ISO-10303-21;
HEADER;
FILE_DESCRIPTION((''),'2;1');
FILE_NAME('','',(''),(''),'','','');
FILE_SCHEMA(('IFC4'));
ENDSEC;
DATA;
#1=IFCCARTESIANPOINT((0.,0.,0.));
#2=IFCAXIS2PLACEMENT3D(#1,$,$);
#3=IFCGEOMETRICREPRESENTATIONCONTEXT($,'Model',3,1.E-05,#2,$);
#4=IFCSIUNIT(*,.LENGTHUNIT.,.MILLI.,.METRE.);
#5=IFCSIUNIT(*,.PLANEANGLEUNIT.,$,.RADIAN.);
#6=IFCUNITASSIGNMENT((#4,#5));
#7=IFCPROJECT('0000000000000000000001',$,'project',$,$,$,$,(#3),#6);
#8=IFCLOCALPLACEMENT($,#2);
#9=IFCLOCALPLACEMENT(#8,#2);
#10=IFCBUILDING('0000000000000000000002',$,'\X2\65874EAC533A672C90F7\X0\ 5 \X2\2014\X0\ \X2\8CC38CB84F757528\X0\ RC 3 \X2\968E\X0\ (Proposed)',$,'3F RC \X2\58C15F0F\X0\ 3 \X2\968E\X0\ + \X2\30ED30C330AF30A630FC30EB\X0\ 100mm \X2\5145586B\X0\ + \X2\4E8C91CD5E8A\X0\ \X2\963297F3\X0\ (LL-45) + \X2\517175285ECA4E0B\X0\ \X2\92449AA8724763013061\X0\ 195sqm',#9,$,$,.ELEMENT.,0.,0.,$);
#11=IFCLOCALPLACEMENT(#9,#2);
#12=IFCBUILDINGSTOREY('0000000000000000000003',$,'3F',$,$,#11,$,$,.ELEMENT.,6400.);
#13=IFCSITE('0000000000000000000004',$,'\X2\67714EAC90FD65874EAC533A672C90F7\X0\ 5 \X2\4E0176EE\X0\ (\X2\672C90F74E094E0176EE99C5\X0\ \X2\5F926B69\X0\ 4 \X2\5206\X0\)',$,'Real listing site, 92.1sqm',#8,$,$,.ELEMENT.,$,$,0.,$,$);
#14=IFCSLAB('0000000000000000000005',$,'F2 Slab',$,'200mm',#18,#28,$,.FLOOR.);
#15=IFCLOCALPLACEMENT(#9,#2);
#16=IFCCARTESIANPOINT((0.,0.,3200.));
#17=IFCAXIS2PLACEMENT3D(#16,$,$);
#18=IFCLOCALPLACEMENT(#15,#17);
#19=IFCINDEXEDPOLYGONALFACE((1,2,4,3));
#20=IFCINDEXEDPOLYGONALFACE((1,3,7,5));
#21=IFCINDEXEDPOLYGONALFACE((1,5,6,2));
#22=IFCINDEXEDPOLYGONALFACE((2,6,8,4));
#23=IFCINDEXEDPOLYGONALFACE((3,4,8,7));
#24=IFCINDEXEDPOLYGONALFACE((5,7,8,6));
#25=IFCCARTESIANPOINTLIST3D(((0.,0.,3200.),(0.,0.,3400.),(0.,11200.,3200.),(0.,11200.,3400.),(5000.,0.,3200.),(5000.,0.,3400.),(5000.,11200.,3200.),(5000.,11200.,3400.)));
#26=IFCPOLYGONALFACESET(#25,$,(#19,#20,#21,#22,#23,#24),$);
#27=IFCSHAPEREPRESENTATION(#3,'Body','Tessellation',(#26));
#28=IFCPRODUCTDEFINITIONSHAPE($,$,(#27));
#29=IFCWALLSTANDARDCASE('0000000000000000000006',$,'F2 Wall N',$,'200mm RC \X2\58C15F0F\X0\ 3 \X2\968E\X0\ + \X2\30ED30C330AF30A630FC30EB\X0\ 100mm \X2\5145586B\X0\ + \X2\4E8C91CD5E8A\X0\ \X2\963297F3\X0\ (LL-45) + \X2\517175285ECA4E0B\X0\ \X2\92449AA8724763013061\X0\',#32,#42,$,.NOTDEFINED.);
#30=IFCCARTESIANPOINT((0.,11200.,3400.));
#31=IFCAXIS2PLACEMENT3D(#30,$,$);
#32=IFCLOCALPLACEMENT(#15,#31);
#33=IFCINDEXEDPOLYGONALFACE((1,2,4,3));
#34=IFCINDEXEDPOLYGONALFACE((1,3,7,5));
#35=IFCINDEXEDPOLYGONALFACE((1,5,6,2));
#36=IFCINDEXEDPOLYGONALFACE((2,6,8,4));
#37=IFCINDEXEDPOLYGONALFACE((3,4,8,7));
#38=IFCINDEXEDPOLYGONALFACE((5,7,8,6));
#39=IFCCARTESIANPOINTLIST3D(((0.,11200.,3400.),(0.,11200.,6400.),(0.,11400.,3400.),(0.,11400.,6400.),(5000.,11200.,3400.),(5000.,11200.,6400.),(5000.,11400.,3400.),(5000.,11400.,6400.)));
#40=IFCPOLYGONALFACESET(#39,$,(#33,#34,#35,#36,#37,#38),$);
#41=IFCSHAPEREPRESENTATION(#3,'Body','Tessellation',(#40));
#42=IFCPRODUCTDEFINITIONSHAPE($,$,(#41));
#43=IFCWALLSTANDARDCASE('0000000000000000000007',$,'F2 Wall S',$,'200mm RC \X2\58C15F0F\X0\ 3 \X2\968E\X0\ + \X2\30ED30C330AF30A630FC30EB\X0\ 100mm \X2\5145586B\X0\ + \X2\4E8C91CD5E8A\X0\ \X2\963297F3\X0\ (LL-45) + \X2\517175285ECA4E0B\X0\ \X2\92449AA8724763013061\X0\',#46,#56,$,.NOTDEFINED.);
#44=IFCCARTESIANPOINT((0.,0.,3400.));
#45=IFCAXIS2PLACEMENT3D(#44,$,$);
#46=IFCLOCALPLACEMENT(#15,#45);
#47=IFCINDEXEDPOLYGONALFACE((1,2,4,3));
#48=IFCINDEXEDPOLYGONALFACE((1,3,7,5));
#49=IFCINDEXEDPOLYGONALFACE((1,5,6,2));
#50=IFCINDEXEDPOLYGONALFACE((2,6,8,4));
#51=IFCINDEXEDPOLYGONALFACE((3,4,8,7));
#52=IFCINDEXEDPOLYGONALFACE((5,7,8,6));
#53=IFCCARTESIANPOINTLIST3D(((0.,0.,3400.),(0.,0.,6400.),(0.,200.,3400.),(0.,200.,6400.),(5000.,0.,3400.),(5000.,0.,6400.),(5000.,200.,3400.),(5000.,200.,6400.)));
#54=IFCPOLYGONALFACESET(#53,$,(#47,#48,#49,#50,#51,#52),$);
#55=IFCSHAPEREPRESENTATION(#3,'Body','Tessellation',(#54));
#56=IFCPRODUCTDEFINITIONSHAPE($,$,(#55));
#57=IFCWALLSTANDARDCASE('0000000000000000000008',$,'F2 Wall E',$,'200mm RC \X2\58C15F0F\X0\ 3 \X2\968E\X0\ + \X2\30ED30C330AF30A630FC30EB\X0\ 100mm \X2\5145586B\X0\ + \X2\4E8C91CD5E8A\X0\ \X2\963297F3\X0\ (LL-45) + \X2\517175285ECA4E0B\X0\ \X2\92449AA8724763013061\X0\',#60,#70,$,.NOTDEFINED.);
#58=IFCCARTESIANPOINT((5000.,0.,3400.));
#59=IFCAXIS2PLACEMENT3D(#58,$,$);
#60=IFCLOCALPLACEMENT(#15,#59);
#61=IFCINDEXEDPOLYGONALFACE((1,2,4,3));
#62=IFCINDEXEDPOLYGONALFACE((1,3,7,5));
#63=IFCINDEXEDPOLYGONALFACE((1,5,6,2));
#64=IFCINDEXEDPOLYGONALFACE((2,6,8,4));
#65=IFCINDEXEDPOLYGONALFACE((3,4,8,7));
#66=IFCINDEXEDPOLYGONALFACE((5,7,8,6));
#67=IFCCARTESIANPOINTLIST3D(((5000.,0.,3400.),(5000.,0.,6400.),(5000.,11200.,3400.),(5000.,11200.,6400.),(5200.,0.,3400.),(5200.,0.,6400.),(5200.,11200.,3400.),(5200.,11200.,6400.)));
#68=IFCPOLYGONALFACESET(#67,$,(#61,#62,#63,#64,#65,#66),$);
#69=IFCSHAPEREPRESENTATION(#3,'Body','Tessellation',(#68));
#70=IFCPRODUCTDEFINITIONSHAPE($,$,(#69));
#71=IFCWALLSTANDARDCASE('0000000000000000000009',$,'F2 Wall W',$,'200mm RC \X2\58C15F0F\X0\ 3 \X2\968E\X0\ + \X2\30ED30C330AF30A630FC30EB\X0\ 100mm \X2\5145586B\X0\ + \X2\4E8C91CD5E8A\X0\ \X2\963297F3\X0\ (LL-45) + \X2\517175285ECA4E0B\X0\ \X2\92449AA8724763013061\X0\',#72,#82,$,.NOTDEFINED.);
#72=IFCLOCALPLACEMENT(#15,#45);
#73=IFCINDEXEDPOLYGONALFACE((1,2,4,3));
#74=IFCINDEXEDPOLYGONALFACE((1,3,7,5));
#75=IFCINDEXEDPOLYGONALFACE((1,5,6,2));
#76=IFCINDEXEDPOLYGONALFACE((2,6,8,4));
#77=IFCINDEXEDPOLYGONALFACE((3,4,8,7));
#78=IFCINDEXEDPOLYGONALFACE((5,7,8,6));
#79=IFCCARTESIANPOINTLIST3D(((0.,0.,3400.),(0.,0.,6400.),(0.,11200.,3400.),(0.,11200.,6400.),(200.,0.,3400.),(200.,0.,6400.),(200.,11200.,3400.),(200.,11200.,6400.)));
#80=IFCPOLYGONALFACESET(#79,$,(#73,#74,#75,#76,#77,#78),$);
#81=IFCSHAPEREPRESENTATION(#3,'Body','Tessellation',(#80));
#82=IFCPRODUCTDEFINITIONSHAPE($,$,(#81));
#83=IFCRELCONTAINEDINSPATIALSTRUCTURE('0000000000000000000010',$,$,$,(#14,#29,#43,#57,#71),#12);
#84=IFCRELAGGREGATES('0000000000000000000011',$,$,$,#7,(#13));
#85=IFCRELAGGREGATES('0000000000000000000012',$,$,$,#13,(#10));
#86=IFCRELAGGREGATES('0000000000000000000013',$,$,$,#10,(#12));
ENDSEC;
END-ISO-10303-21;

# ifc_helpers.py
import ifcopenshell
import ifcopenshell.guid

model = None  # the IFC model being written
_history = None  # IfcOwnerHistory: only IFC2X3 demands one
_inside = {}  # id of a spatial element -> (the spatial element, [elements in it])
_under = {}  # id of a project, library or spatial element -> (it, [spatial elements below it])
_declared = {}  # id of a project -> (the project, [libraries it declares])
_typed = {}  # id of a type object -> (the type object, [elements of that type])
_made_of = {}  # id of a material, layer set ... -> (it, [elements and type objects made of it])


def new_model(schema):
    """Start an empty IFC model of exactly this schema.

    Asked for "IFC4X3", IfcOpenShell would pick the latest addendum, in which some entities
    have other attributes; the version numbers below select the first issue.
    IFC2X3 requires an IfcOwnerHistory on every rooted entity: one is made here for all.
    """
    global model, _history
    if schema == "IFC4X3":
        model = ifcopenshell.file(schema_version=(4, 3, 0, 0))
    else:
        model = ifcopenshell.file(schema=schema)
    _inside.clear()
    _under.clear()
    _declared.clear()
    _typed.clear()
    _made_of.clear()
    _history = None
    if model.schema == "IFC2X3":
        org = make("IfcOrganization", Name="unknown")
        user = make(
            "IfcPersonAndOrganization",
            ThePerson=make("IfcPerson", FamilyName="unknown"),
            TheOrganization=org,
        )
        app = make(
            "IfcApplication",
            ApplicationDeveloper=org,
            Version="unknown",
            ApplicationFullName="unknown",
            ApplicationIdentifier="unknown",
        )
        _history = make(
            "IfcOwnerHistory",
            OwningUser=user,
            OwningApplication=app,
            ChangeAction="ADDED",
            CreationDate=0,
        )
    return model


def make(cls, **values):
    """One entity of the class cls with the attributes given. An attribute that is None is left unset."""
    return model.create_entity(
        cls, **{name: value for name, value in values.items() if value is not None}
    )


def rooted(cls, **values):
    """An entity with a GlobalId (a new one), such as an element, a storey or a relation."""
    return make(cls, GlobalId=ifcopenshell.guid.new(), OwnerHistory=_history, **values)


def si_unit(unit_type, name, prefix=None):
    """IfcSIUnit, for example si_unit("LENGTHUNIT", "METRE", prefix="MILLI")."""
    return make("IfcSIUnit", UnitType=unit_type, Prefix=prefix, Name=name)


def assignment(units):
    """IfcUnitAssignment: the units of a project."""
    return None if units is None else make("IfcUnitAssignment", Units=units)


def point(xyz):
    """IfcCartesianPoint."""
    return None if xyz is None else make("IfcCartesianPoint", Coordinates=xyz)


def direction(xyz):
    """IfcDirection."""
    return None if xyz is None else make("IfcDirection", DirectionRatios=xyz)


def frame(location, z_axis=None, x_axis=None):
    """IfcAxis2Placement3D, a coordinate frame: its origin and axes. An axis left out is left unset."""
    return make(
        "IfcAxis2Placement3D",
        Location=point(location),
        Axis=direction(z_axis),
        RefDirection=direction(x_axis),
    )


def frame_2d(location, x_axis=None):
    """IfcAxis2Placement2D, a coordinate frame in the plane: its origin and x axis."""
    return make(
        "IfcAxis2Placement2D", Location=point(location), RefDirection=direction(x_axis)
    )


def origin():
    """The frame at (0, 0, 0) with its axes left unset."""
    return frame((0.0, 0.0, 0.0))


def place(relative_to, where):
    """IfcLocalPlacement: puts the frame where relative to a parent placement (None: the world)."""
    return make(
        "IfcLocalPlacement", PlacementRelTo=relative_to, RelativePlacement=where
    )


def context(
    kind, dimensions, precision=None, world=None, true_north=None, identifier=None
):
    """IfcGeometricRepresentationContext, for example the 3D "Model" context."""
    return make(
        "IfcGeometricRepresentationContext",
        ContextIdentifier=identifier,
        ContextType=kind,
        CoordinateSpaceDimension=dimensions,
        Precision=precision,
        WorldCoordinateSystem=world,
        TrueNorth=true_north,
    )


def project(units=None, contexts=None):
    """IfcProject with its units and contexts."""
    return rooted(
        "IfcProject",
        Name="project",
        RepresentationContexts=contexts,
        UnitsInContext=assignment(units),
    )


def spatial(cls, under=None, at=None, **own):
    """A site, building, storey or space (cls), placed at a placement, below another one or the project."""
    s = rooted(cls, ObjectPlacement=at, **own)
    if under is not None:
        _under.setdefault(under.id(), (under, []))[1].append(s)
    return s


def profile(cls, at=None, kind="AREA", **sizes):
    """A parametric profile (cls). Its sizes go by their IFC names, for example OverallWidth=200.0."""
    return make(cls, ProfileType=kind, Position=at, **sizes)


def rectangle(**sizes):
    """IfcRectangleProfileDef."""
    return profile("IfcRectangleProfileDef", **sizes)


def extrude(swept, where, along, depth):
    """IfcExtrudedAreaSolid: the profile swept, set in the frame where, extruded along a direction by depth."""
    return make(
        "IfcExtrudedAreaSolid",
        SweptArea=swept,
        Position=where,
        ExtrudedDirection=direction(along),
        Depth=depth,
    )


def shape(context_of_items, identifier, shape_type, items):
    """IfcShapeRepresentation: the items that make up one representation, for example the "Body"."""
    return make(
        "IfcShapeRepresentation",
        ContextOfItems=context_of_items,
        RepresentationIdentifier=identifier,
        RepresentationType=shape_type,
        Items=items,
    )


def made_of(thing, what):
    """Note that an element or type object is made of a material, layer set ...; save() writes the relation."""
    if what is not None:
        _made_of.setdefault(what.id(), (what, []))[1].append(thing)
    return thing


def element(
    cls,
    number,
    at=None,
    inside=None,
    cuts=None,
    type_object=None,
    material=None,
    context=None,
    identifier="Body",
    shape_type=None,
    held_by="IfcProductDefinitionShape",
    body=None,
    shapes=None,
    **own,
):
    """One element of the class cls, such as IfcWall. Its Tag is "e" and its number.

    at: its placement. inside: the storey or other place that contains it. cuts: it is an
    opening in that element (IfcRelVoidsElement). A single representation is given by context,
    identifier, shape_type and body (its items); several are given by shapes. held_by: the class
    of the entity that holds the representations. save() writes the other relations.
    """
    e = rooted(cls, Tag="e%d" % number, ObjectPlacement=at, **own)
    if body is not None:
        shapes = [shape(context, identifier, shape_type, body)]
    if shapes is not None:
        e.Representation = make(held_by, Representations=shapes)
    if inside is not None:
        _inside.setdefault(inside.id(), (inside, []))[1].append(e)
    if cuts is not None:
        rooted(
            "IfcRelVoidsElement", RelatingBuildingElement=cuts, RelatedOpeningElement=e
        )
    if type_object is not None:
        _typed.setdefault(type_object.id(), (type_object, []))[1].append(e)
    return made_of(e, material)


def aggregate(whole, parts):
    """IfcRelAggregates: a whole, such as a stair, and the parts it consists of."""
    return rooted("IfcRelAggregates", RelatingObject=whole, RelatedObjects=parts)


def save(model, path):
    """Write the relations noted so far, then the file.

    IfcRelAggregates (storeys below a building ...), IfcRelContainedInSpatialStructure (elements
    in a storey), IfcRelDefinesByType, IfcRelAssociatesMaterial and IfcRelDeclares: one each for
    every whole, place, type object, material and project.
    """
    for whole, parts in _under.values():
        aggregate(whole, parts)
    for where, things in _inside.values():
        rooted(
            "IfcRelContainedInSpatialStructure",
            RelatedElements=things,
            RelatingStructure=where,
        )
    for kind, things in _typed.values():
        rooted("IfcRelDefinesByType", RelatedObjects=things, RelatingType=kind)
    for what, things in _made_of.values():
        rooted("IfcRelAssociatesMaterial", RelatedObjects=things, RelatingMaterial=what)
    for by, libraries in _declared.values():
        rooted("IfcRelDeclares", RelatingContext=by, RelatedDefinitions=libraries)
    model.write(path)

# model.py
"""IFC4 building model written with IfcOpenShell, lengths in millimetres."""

from ifc_helpers import new_model, si_unit, frame, frame_2d, origin, place, context, project, spatial, rectangle, extrude, element, save


model = new_model("IFC4")

# Units and contexts
model_context = context("Model", 3, precision=1e-05, world=origin())
ifc_project = project(units=[si_unit("LENGTHUNIT", "METRE", prefix="MILLI"), si_unit("PLANEANGLEUNIT", "RADIAN")], contexts=[model_context])

# Site, building, storey
site_placement = place(None, origin())
site = spatial("IfcSite", under=ifc_project, at=site_placement, Name="東京都文京区本郷 5 丁目 (本郷三丁目駅 徒歩 4 分)", ObjectType="Real listing site, 92.1sqm", CompositionType="ELEMENT", RefElevation=0.0)
building_placement = place(site_placement, origin())
building = spatial("IfcBuilding", under=site, at=building_placement, Name="文京区本郷 5 — 賃貸併用 RC 3 階 (Proposed)", ObjectType="3F RC 壁式 3 階 + ロックウール 100mm 充填 + 二重床 防音 (LL-45) + 共用廊下 鉄骨片持ち 195sqm", CompositionType="ELEMENT", ElevationOfRefHeight=0.0, ElevationOfTerrain=0.0)
storey_placement = place(building_placement, origin())
storey = spatial("IfcBuildingStorey", under=building, at=storey_placement, Name="3F", CompositionType="ELEMENT", Elevation=6400.0)

# Slab
placement = place(building_placement, origin())
slab_placement = place(placement, frame((0.0, 0.0, 3200.0)))
element("IfcSlab", 1, at=slab_placement, inside=storey, Name="F2 Slab", ObjectType="200mm", PredefinedType="FLOOR", context=model_context, shape_type="SweptSolid", body=[
    extrude(rectangle(XDim=5000.0, YDim=11200.0, at=frame_2d((2500.0, 5600.0))), frame((0.0, 0.0, 3200.0)), (0.0, 0.0, 1.0), 200.0),
])

# Walls
wall_1_placement = place(placement, frame((0.0, 11200.0, 3400.0)))
element("IfcWallStandardCase", 2, at=wall_1_placement, inside=storey, Name="F2 Wall N", ObjectType="200mm RC 壁式 3 階 + ロックウール 100mm 充填 + 二重床 防音 (LL-45) + 共用廊下 鉄骨片持ち", PredefinedType="NOTDEFINED", context=model_context, shape_type="SweptSolid", body=[
    extrude(rectangle(XDim=5000.0, YDim=200.0, at=frame_2d((2500.0, 100.0))), frame((0.0, 11200.0, 3400.0)), (0.0, 0.0, 1.0), 3000.0),
])
wall_2_placement = place(placement, frame((0.0, 0.0, 3400.0)))
element("IfcWallStandardCase", 3, at=wall_2_placement, inside=storey, Name="F2 Wall S", ObjectType="200mm RC 壁式 3 階 + ロックウール 100mm 充填 + 二重床 防音 (LL-45) + 共用廊下 鉄骨片持ち", PredefinedType="NOTDEFINED", context=model_context, shape_type="SweptSolid", body=[
    extrude(rectangle(XDim=5000.0, YDim=200.0, at=frame_2d((2500.0, 100.0))), frame((0.0, 0.0, 3400.0)), (0.0, 0.0, 1.0), 3000.0),
])
wall_3_placement = place(placement, frame((5000.0, 0.0, 3400.0)))
element("IfcWallStandardCase", 4, at=wall_3_placement, inside=storey, Name="F2 Wall E", ObjectType="200mm RC 壁式 3 階 + ロックウール 100mm 充填 + 二重床 防音 (LL-45) + 共用廊下 鉄骨片持ち", PredefinedType="NOTDEFINED", context=model_context, shape_type="SweptSolid", body=[
    extrude(rectangle(XDim=200.0, YDim=11200.0, at=frame_2d((100.0, 5600.0))), frame((5000.0, 0.0, 3400.0)), (0.0, 0.0, 1.0), 3000.0),
])
wall_4_placement = place(placement, frame((0.0, 0.0, 3400.0)))
element("IfcWallStandardCase", 5, at=wall_4_placement, inside=storey, Name="F2 Wall W", ObjectType="200mm RC 壁式 3 階 + ロックウール 100mm 充填 + 二重床 防音 (LL-45) + 共用廊下 鉄骨片持ち", PredefinedType="NOTDEFINED", context=model_context, shape_type="SweptSolid", body=[
    extrude(rectangle(XDim=200.0, YDim=11200.0, at=frame_2d((100.0, 5600.0))), frame((0.0, 0.0, 3400.0)), (0.0, 0.0, 1.0), 3000.0),
])

save(model, "model.ifc")
